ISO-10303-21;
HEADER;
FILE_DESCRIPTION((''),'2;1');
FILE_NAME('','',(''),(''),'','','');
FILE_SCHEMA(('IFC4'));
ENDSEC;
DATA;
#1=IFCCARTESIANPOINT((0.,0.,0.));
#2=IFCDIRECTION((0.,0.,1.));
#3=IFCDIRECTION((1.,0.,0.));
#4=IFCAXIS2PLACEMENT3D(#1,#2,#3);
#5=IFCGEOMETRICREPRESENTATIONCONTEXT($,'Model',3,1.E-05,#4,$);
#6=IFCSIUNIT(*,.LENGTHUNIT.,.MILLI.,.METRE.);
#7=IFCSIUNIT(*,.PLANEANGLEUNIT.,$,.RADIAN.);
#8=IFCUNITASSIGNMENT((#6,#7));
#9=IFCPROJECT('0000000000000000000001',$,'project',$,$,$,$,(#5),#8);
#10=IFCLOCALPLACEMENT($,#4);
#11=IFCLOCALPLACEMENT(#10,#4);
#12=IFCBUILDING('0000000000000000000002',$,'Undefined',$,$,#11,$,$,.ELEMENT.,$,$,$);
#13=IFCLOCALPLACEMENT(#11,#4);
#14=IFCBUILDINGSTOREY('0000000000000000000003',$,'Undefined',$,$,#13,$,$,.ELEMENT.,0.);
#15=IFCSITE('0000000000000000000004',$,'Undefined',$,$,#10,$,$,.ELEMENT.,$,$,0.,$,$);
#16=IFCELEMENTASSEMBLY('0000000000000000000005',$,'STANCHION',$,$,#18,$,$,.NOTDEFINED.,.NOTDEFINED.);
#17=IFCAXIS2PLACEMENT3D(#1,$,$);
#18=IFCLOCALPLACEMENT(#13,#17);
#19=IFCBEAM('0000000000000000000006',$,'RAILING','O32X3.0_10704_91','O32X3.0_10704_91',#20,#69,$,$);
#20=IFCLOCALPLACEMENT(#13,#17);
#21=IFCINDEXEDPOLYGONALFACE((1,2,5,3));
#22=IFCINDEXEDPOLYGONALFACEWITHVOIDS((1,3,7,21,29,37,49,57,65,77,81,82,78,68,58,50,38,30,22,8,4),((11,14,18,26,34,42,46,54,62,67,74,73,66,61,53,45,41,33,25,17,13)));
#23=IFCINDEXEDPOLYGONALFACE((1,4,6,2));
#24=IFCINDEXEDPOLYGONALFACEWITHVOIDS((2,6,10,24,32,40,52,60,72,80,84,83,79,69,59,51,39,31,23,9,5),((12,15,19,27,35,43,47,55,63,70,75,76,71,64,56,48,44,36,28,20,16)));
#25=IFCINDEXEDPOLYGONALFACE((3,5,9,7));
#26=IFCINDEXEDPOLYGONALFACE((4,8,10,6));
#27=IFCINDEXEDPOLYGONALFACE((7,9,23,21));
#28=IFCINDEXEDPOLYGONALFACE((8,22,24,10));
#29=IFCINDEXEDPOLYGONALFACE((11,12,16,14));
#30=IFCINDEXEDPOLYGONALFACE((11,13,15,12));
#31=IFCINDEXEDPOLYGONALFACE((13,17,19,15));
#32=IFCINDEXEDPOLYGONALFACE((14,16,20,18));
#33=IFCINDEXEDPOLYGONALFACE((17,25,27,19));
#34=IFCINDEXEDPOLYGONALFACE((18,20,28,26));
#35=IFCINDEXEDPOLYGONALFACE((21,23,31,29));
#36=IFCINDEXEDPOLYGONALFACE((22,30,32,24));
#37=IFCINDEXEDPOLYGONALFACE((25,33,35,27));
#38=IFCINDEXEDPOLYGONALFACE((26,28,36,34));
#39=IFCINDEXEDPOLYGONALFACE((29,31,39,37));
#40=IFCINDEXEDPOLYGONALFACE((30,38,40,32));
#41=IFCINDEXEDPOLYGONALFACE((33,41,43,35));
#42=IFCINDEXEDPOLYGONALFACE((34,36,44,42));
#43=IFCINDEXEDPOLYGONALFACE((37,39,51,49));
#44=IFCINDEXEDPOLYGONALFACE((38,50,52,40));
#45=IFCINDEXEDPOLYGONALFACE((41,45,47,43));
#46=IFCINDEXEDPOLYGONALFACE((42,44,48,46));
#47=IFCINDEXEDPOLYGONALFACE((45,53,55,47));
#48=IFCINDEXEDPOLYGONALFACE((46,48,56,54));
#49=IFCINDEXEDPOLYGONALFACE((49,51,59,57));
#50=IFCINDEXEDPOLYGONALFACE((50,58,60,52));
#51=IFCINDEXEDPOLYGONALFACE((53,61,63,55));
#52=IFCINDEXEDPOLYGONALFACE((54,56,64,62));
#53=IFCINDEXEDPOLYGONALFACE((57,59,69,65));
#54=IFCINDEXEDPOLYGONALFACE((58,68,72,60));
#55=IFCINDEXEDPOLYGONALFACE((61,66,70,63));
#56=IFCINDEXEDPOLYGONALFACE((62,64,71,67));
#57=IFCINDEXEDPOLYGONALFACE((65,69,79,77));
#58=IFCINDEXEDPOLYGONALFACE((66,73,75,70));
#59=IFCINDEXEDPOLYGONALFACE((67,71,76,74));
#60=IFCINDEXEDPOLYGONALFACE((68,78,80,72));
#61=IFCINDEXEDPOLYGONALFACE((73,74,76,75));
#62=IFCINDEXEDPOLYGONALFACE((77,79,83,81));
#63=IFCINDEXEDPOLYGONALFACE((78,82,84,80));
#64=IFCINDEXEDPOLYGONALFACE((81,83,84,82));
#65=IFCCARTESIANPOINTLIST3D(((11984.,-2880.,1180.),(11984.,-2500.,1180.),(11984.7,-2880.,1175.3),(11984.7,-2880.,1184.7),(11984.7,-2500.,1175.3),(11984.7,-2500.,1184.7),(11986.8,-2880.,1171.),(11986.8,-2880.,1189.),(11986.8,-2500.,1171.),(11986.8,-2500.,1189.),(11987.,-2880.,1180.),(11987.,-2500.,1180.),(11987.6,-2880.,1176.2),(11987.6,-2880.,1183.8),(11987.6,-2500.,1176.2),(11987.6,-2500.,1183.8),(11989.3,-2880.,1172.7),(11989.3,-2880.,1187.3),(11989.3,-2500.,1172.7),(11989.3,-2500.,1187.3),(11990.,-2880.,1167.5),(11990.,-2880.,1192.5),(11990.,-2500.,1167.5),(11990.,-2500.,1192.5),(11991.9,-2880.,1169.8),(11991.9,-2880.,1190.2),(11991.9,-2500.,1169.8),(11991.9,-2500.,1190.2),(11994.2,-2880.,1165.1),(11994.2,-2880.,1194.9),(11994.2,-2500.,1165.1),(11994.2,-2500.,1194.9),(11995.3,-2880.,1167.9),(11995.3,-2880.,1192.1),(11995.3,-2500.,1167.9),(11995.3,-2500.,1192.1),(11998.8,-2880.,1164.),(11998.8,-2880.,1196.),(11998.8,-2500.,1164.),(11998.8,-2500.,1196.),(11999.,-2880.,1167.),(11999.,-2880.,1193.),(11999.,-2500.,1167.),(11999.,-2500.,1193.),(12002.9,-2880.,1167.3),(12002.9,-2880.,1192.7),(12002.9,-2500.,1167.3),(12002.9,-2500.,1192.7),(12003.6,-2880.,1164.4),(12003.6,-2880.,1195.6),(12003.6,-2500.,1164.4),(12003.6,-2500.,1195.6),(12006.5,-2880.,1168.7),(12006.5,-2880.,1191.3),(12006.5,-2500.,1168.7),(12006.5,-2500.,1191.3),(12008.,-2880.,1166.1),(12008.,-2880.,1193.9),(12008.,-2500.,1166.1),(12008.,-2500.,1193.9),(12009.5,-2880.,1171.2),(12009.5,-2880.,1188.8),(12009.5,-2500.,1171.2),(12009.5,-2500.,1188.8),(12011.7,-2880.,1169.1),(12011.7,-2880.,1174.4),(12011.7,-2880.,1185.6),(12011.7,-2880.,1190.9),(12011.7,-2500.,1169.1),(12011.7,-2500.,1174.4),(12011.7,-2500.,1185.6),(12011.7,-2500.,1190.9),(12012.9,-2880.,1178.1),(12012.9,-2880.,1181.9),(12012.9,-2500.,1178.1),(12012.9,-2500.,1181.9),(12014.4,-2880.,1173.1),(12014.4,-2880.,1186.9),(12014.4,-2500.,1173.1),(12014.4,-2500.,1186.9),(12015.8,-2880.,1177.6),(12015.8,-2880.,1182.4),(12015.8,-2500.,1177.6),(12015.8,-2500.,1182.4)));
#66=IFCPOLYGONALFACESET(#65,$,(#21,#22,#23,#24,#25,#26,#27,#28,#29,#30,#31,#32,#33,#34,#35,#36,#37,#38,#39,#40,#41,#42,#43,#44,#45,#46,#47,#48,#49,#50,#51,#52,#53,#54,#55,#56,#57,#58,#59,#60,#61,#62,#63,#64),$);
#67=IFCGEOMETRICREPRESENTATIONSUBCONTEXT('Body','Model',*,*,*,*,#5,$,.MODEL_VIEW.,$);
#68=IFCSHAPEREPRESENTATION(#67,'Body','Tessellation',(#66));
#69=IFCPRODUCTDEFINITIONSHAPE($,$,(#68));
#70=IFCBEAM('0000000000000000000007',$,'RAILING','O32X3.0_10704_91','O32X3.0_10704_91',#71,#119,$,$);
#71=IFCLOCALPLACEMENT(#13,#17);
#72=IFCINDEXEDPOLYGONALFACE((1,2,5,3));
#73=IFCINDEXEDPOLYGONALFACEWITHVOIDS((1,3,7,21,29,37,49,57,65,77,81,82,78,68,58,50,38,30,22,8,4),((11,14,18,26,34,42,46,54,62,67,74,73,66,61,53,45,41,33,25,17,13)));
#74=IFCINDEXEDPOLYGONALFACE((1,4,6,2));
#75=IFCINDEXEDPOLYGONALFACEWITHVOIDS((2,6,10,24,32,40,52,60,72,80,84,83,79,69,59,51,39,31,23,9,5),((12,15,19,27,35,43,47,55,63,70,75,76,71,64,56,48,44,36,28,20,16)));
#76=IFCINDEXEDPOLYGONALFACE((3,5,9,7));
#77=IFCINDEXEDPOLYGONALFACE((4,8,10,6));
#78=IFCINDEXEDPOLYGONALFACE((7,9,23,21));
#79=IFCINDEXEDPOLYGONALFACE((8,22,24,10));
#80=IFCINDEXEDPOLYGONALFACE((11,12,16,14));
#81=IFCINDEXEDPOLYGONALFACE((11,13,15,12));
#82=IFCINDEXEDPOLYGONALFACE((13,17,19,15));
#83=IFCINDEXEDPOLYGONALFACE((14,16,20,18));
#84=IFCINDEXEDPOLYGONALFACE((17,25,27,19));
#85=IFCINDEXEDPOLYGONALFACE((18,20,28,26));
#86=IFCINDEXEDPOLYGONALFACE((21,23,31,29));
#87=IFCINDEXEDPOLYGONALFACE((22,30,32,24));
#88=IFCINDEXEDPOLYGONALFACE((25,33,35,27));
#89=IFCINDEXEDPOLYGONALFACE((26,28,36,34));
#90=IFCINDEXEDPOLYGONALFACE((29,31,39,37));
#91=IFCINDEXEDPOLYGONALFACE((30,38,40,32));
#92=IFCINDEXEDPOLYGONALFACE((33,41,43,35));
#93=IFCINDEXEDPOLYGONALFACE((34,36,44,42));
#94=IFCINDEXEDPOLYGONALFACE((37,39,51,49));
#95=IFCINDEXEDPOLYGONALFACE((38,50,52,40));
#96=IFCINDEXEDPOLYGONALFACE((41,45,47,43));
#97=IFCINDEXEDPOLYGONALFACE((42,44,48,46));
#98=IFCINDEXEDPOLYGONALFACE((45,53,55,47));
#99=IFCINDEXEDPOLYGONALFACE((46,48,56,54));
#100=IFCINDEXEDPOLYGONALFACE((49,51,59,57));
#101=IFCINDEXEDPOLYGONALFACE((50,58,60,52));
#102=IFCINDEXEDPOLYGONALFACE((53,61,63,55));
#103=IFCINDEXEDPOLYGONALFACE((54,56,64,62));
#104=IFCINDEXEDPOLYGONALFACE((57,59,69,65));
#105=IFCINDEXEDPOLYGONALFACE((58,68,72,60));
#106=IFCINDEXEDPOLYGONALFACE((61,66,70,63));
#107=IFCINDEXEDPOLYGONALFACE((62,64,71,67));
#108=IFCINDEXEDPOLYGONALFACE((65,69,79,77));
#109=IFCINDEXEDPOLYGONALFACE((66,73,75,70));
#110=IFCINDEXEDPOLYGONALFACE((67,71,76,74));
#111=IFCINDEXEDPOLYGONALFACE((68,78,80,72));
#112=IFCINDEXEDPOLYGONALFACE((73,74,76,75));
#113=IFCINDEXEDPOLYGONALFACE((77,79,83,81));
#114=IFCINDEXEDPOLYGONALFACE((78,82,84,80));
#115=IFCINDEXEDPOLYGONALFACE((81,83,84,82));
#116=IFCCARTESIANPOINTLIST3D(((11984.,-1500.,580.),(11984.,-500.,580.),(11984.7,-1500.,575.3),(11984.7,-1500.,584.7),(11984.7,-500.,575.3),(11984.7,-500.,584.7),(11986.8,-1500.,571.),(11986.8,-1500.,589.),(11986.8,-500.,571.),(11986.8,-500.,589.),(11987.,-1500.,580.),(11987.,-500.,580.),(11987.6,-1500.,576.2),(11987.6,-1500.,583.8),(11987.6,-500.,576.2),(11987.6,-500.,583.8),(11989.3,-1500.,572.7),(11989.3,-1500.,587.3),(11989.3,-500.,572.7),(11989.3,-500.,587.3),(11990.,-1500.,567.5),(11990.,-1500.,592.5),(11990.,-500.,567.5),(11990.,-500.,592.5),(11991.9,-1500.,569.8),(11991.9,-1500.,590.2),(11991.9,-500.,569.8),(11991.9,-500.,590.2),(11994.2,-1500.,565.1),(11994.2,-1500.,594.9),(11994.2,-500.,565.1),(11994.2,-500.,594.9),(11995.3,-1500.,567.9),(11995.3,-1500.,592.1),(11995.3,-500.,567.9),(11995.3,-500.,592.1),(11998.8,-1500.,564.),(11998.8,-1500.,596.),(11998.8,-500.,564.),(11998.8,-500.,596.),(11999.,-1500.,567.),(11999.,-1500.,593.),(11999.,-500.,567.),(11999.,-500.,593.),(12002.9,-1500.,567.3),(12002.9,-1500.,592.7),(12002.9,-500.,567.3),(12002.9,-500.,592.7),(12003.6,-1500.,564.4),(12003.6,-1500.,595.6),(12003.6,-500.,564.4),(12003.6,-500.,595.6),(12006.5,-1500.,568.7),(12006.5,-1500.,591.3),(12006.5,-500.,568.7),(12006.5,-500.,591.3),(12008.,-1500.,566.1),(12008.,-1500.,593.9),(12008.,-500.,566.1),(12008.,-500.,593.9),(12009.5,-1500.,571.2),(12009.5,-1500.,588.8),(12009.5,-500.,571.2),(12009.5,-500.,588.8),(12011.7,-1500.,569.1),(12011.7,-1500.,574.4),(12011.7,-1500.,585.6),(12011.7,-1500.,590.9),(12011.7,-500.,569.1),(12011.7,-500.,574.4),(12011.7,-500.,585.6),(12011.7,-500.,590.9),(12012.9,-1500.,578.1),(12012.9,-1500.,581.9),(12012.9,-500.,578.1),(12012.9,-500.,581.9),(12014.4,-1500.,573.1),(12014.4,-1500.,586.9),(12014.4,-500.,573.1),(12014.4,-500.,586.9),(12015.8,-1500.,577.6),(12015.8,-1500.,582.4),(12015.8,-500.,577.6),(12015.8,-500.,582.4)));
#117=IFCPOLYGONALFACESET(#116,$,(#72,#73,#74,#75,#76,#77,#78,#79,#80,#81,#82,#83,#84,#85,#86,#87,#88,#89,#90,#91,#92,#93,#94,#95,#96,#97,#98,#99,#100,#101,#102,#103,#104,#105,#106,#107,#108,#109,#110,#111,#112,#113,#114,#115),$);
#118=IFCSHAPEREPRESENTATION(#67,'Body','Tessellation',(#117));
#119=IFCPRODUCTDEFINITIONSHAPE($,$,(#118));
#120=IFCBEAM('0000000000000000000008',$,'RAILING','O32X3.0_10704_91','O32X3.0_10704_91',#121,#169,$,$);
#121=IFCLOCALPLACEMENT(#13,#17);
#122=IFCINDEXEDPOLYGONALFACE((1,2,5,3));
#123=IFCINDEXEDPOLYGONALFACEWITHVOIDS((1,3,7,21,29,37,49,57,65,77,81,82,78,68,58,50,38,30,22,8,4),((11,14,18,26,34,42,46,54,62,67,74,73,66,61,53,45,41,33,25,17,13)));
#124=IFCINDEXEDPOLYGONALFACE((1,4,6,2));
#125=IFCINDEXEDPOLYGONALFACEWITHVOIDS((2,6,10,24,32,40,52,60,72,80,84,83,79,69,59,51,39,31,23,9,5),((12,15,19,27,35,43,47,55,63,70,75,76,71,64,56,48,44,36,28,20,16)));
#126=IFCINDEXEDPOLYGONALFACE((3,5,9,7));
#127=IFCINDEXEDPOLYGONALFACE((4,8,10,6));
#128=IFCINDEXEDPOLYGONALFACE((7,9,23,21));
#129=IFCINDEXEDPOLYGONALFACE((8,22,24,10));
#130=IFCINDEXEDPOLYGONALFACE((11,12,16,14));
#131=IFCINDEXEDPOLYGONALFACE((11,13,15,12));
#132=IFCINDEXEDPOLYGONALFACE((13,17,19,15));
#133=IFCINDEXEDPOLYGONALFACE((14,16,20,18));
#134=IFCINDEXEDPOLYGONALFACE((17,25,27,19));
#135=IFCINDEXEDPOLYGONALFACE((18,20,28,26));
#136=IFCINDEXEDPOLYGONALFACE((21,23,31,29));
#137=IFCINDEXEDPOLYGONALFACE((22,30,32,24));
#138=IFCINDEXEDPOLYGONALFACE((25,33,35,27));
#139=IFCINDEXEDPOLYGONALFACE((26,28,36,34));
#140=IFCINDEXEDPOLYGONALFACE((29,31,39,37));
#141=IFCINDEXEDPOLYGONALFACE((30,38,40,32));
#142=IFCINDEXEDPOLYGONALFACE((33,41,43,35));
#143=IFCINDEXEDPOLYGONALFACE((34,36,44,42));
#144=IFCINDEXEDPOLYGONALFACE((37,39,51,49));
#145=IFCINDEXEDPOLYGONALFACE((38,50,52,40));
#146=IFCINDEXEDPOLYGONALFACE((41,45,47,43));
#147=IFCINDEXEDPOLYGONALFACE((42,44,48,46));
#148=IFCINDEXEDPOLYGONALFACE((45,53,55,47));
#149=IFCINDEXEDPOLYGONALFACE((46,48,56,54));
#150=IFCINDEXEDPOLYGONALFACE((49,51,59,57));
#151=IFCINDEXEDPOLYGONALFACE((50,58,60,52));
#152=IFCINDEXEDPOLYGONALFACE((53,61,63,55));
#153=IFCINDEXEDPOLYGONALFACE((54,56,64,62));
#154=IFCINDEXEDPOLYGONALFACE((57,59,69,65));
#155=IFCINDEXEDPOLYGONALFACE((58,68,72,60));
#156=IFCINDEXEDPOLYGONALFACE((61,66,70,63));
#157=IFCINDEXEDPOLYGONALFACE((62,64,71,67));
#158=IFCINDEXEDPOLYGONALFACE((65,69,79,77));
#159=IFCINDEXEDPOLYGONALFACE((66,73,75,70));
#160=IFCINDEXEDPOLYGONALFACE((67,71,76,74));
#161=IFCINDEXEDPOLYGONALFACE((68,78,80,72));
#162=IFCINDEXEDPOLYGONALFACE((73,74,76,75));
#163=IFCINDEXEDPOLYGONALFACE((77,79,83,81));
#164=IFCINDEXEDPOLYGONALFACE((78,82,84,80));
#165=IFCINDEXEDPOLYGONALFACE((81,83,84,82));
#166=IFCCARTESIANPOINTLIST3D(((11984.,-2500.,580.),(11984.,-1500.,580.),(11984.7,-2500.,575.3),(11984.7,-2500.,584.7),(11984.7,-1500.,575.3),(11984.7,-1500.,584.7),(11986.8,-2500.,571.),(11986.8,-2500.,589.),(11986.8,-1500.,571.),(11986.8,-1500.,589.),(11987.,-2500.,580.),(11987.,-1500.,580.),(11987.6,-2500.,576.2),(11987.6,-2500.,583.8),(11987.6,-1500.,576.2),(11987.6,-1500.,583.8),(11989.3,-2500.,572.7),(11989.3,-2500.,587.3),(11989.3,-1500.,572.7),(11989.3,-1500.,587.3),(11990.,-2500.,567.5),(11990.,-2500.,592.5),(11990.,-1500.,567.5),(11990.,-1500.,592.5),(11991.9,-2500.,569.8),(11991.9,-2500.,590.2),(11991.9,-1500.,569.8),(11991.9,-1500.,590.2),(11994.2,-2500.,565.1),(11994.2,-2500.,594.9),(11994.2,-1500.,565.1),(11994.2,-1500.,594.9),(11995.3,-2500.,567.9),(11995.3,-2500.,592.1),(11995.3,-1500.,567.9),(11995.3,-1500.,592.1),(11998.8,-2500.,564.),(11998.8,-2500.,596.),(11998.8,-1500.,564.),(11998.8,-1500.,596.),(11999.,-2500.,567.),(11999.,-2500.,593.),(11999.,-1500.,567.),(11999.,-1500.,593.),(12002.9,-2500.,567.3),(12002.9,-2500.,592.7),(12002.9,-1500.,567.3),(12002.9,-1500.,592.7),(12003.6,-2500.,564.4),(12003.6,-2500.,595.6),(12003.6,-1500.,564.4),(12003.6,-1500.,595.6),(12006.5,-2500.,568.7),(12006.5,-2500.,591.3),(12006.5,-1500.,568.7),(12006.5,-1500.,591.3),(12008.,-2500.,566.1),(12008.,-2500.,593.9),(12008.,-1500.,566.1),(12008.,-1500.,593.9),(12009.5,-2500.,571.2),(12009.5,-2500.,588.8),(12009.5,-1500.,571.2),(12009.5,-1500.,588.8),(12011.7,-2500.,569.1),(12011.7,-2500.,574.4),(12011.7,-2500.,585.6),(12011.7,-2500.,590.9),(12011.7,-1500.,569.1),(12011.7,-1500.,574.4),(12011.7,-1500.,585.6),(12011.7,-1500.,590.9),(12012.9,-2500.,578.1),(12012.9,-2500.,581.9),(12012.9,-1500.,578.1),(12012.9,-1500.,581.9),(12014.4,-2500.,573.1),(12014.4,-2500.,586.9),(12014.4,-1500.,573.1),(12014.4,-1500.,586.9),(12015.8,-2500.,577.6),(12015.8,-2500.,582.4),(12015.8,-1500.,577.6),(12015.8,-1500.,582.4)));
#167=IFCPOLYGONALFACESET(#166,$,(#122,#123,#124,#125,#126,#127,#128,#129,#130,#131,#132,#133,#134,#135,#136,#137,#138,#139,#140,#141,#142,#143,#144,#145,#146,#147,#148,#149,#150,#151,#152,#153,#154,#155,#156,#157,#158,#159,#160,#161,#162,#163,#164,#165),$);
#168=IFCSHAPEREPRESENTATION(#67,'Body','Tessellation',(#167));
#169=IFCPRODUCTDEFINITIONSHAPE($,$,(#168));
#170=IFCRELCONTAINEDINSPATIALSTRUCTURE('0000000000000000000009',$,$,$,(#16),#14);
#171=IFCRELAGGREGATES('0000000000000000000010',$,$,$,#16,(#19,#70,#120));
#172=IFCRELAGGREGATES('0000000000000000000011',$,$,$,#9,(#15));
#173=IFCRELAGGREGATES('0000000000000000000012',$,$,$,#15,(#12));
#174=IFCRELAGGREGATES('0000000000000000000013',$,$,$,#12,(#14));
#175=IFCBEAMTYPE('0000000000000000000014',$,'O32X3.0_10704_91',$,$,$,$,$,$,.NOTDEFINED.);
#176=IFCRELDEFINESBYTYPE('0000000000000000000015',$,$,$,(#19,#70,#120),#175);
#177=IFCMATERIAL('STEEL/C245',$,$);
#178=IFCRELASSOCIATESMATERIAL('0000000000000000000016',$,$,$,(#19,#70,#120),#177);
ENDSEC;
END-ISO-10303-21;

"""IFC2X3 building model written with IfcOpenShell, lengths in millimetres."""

from ifc_helpers import new_model, si_unit, frame, origin_with_axes, origin_2d_with_axis, place, context, subcontext, project, spatial, hollow_circle, extrude, material, type_object, element, aggregate, save


model = new_model("IFC2X3")

# Units and contexts
model_context = context("Model", 3, precision=1e-05, world=origin_with_axes())
body_context = subcontext(model_context, "Body", "Model", "MODEL_VIEW")
ifc_project = project(units=[si_unit("LENGTHUNIT", "METRE", prefix="MILLI"), si_unit("PLANEANGLEUNIT", "RADIAN")], contexts=[model_context])

# Site, building, storey
site_placement = place(None, origin_with_axes())
site = spatial("IfcSite", under=ifc_project, at=site_placement, Name="Undefined", CompositionType="ELEMENT", RefElevation=0.0)
building_placement = place(site_placement, origin_with_axes())
building = spatial("IfcBuilding", under=site, at=building_placement, Name="Undefined", CompositionType="ELEMENT")
storey_placement = place(building_placement, origin_with_axes())
storey = spatial("IfcBuildingStorey", under=building, at=storey_placement, Name="Undefined", CompositionType="ELEMENT", Elevation=0.0)

# Element assembly
ifc_material_1 = material(Name="STEEL/C245")
assembly_1_placement = place(storey_placement, origin_with_axes())
assembly_1 = element("IfcElementAssembly", 1, at=assembly_1_placement, inside=storey, Name="STANCHION", AssemblyPlace="NOTDEFINED", PredefinedType="NOTDEFINED")

# Beams
beam_type_1 = type_object("IfcBeamType", Name="O32X3.0_10704_91", PredefinedType="NOTDEFINED")
beam_1_placement = place(assembly_1_placement, frame((12000.0, -2880.0, 1180.0), z_axis=(0.0, 0.0, -1.0), x_axis=(0.0, 1.0, 0.0)))
beam_1 = element("IfcBeam", 2, at=beam_1_placement, type_object=beam_type_1, material=ifc_material_1, Name="RAILING", Description="O32X3.0_10704_91", ObjectType="O32X3.0_10704_91", context=body_context, shape_type="SweptSolid", body=[
    extrude(hollow_circle(Radius=16.0, WallThickness=3.0, at=origin_2d_with_axis()), frame((380.0, 0.0, 0.0), z_axis=(-1.0, 0.0, 0.0), x_axis=(0.0, -1.0, 0.0)), (0.0, 0.0, 1.0), 380.0),
])
beam_2_placement = place(assembly_1_placement, frame((12000.0, -1500.0, 580.0), z_axis=(0.0, 0.0, -1.0), x_axis=(0.0, 1.0, 0.0)))
beam_2 = element("IfcBeam", 3, at=beam_2_placement, type_object=beam_type_1, material=ifc_material_1, Name="RAILING", Description="O32X3.0_10704_91", ObjectType="O32X3.0_10704_91", context=body_context, shape_type="SweptSolid", body=[
    extrude(hollow_circle(Radius=16.0, WallThickness=3.0, at=origin_2d_with_axis()), frame((1000.0, 0.0, 0.0), z_axis=(-1.0, 0.0, 0.0), x_axis=(0.0, -1.0, 0.0)), (0.0, 0.0, 1.0), 1000.0),
])
beam_3_placement = place(assembly_1_placement, frame((12000.0, -2500.0, 580.0), z_axis=(0.0, 0.0, -1.0), x_axis=(0.0, 1.0, 0.0)))
beam_3 = element("IfcBeam", 4, at=beam_3_placement, type_object=beam_type_1, material=ifc_material_1, Name="RAILING", Description="O32X3.0_10704_91", ObjectType="O32X3.0_10704_91", context=body_context, shape_type="SweptSolid", body=[
    extrude(hollow_circle(Radius=16.0, WallThickness=3.0, at=origin_2d_with_axis()), frame((1000.0, 0.0, 0.0), z_axis=(-1.0, 0.0, 0.0), x_axis=(0.0, -1.0, 0.0)), (0.0, 0.0, 1.0), 1000.0),
])
aggregate(assembly_1, [beam_1, beam_2, beam_3])

save(model, "model.ifc")
